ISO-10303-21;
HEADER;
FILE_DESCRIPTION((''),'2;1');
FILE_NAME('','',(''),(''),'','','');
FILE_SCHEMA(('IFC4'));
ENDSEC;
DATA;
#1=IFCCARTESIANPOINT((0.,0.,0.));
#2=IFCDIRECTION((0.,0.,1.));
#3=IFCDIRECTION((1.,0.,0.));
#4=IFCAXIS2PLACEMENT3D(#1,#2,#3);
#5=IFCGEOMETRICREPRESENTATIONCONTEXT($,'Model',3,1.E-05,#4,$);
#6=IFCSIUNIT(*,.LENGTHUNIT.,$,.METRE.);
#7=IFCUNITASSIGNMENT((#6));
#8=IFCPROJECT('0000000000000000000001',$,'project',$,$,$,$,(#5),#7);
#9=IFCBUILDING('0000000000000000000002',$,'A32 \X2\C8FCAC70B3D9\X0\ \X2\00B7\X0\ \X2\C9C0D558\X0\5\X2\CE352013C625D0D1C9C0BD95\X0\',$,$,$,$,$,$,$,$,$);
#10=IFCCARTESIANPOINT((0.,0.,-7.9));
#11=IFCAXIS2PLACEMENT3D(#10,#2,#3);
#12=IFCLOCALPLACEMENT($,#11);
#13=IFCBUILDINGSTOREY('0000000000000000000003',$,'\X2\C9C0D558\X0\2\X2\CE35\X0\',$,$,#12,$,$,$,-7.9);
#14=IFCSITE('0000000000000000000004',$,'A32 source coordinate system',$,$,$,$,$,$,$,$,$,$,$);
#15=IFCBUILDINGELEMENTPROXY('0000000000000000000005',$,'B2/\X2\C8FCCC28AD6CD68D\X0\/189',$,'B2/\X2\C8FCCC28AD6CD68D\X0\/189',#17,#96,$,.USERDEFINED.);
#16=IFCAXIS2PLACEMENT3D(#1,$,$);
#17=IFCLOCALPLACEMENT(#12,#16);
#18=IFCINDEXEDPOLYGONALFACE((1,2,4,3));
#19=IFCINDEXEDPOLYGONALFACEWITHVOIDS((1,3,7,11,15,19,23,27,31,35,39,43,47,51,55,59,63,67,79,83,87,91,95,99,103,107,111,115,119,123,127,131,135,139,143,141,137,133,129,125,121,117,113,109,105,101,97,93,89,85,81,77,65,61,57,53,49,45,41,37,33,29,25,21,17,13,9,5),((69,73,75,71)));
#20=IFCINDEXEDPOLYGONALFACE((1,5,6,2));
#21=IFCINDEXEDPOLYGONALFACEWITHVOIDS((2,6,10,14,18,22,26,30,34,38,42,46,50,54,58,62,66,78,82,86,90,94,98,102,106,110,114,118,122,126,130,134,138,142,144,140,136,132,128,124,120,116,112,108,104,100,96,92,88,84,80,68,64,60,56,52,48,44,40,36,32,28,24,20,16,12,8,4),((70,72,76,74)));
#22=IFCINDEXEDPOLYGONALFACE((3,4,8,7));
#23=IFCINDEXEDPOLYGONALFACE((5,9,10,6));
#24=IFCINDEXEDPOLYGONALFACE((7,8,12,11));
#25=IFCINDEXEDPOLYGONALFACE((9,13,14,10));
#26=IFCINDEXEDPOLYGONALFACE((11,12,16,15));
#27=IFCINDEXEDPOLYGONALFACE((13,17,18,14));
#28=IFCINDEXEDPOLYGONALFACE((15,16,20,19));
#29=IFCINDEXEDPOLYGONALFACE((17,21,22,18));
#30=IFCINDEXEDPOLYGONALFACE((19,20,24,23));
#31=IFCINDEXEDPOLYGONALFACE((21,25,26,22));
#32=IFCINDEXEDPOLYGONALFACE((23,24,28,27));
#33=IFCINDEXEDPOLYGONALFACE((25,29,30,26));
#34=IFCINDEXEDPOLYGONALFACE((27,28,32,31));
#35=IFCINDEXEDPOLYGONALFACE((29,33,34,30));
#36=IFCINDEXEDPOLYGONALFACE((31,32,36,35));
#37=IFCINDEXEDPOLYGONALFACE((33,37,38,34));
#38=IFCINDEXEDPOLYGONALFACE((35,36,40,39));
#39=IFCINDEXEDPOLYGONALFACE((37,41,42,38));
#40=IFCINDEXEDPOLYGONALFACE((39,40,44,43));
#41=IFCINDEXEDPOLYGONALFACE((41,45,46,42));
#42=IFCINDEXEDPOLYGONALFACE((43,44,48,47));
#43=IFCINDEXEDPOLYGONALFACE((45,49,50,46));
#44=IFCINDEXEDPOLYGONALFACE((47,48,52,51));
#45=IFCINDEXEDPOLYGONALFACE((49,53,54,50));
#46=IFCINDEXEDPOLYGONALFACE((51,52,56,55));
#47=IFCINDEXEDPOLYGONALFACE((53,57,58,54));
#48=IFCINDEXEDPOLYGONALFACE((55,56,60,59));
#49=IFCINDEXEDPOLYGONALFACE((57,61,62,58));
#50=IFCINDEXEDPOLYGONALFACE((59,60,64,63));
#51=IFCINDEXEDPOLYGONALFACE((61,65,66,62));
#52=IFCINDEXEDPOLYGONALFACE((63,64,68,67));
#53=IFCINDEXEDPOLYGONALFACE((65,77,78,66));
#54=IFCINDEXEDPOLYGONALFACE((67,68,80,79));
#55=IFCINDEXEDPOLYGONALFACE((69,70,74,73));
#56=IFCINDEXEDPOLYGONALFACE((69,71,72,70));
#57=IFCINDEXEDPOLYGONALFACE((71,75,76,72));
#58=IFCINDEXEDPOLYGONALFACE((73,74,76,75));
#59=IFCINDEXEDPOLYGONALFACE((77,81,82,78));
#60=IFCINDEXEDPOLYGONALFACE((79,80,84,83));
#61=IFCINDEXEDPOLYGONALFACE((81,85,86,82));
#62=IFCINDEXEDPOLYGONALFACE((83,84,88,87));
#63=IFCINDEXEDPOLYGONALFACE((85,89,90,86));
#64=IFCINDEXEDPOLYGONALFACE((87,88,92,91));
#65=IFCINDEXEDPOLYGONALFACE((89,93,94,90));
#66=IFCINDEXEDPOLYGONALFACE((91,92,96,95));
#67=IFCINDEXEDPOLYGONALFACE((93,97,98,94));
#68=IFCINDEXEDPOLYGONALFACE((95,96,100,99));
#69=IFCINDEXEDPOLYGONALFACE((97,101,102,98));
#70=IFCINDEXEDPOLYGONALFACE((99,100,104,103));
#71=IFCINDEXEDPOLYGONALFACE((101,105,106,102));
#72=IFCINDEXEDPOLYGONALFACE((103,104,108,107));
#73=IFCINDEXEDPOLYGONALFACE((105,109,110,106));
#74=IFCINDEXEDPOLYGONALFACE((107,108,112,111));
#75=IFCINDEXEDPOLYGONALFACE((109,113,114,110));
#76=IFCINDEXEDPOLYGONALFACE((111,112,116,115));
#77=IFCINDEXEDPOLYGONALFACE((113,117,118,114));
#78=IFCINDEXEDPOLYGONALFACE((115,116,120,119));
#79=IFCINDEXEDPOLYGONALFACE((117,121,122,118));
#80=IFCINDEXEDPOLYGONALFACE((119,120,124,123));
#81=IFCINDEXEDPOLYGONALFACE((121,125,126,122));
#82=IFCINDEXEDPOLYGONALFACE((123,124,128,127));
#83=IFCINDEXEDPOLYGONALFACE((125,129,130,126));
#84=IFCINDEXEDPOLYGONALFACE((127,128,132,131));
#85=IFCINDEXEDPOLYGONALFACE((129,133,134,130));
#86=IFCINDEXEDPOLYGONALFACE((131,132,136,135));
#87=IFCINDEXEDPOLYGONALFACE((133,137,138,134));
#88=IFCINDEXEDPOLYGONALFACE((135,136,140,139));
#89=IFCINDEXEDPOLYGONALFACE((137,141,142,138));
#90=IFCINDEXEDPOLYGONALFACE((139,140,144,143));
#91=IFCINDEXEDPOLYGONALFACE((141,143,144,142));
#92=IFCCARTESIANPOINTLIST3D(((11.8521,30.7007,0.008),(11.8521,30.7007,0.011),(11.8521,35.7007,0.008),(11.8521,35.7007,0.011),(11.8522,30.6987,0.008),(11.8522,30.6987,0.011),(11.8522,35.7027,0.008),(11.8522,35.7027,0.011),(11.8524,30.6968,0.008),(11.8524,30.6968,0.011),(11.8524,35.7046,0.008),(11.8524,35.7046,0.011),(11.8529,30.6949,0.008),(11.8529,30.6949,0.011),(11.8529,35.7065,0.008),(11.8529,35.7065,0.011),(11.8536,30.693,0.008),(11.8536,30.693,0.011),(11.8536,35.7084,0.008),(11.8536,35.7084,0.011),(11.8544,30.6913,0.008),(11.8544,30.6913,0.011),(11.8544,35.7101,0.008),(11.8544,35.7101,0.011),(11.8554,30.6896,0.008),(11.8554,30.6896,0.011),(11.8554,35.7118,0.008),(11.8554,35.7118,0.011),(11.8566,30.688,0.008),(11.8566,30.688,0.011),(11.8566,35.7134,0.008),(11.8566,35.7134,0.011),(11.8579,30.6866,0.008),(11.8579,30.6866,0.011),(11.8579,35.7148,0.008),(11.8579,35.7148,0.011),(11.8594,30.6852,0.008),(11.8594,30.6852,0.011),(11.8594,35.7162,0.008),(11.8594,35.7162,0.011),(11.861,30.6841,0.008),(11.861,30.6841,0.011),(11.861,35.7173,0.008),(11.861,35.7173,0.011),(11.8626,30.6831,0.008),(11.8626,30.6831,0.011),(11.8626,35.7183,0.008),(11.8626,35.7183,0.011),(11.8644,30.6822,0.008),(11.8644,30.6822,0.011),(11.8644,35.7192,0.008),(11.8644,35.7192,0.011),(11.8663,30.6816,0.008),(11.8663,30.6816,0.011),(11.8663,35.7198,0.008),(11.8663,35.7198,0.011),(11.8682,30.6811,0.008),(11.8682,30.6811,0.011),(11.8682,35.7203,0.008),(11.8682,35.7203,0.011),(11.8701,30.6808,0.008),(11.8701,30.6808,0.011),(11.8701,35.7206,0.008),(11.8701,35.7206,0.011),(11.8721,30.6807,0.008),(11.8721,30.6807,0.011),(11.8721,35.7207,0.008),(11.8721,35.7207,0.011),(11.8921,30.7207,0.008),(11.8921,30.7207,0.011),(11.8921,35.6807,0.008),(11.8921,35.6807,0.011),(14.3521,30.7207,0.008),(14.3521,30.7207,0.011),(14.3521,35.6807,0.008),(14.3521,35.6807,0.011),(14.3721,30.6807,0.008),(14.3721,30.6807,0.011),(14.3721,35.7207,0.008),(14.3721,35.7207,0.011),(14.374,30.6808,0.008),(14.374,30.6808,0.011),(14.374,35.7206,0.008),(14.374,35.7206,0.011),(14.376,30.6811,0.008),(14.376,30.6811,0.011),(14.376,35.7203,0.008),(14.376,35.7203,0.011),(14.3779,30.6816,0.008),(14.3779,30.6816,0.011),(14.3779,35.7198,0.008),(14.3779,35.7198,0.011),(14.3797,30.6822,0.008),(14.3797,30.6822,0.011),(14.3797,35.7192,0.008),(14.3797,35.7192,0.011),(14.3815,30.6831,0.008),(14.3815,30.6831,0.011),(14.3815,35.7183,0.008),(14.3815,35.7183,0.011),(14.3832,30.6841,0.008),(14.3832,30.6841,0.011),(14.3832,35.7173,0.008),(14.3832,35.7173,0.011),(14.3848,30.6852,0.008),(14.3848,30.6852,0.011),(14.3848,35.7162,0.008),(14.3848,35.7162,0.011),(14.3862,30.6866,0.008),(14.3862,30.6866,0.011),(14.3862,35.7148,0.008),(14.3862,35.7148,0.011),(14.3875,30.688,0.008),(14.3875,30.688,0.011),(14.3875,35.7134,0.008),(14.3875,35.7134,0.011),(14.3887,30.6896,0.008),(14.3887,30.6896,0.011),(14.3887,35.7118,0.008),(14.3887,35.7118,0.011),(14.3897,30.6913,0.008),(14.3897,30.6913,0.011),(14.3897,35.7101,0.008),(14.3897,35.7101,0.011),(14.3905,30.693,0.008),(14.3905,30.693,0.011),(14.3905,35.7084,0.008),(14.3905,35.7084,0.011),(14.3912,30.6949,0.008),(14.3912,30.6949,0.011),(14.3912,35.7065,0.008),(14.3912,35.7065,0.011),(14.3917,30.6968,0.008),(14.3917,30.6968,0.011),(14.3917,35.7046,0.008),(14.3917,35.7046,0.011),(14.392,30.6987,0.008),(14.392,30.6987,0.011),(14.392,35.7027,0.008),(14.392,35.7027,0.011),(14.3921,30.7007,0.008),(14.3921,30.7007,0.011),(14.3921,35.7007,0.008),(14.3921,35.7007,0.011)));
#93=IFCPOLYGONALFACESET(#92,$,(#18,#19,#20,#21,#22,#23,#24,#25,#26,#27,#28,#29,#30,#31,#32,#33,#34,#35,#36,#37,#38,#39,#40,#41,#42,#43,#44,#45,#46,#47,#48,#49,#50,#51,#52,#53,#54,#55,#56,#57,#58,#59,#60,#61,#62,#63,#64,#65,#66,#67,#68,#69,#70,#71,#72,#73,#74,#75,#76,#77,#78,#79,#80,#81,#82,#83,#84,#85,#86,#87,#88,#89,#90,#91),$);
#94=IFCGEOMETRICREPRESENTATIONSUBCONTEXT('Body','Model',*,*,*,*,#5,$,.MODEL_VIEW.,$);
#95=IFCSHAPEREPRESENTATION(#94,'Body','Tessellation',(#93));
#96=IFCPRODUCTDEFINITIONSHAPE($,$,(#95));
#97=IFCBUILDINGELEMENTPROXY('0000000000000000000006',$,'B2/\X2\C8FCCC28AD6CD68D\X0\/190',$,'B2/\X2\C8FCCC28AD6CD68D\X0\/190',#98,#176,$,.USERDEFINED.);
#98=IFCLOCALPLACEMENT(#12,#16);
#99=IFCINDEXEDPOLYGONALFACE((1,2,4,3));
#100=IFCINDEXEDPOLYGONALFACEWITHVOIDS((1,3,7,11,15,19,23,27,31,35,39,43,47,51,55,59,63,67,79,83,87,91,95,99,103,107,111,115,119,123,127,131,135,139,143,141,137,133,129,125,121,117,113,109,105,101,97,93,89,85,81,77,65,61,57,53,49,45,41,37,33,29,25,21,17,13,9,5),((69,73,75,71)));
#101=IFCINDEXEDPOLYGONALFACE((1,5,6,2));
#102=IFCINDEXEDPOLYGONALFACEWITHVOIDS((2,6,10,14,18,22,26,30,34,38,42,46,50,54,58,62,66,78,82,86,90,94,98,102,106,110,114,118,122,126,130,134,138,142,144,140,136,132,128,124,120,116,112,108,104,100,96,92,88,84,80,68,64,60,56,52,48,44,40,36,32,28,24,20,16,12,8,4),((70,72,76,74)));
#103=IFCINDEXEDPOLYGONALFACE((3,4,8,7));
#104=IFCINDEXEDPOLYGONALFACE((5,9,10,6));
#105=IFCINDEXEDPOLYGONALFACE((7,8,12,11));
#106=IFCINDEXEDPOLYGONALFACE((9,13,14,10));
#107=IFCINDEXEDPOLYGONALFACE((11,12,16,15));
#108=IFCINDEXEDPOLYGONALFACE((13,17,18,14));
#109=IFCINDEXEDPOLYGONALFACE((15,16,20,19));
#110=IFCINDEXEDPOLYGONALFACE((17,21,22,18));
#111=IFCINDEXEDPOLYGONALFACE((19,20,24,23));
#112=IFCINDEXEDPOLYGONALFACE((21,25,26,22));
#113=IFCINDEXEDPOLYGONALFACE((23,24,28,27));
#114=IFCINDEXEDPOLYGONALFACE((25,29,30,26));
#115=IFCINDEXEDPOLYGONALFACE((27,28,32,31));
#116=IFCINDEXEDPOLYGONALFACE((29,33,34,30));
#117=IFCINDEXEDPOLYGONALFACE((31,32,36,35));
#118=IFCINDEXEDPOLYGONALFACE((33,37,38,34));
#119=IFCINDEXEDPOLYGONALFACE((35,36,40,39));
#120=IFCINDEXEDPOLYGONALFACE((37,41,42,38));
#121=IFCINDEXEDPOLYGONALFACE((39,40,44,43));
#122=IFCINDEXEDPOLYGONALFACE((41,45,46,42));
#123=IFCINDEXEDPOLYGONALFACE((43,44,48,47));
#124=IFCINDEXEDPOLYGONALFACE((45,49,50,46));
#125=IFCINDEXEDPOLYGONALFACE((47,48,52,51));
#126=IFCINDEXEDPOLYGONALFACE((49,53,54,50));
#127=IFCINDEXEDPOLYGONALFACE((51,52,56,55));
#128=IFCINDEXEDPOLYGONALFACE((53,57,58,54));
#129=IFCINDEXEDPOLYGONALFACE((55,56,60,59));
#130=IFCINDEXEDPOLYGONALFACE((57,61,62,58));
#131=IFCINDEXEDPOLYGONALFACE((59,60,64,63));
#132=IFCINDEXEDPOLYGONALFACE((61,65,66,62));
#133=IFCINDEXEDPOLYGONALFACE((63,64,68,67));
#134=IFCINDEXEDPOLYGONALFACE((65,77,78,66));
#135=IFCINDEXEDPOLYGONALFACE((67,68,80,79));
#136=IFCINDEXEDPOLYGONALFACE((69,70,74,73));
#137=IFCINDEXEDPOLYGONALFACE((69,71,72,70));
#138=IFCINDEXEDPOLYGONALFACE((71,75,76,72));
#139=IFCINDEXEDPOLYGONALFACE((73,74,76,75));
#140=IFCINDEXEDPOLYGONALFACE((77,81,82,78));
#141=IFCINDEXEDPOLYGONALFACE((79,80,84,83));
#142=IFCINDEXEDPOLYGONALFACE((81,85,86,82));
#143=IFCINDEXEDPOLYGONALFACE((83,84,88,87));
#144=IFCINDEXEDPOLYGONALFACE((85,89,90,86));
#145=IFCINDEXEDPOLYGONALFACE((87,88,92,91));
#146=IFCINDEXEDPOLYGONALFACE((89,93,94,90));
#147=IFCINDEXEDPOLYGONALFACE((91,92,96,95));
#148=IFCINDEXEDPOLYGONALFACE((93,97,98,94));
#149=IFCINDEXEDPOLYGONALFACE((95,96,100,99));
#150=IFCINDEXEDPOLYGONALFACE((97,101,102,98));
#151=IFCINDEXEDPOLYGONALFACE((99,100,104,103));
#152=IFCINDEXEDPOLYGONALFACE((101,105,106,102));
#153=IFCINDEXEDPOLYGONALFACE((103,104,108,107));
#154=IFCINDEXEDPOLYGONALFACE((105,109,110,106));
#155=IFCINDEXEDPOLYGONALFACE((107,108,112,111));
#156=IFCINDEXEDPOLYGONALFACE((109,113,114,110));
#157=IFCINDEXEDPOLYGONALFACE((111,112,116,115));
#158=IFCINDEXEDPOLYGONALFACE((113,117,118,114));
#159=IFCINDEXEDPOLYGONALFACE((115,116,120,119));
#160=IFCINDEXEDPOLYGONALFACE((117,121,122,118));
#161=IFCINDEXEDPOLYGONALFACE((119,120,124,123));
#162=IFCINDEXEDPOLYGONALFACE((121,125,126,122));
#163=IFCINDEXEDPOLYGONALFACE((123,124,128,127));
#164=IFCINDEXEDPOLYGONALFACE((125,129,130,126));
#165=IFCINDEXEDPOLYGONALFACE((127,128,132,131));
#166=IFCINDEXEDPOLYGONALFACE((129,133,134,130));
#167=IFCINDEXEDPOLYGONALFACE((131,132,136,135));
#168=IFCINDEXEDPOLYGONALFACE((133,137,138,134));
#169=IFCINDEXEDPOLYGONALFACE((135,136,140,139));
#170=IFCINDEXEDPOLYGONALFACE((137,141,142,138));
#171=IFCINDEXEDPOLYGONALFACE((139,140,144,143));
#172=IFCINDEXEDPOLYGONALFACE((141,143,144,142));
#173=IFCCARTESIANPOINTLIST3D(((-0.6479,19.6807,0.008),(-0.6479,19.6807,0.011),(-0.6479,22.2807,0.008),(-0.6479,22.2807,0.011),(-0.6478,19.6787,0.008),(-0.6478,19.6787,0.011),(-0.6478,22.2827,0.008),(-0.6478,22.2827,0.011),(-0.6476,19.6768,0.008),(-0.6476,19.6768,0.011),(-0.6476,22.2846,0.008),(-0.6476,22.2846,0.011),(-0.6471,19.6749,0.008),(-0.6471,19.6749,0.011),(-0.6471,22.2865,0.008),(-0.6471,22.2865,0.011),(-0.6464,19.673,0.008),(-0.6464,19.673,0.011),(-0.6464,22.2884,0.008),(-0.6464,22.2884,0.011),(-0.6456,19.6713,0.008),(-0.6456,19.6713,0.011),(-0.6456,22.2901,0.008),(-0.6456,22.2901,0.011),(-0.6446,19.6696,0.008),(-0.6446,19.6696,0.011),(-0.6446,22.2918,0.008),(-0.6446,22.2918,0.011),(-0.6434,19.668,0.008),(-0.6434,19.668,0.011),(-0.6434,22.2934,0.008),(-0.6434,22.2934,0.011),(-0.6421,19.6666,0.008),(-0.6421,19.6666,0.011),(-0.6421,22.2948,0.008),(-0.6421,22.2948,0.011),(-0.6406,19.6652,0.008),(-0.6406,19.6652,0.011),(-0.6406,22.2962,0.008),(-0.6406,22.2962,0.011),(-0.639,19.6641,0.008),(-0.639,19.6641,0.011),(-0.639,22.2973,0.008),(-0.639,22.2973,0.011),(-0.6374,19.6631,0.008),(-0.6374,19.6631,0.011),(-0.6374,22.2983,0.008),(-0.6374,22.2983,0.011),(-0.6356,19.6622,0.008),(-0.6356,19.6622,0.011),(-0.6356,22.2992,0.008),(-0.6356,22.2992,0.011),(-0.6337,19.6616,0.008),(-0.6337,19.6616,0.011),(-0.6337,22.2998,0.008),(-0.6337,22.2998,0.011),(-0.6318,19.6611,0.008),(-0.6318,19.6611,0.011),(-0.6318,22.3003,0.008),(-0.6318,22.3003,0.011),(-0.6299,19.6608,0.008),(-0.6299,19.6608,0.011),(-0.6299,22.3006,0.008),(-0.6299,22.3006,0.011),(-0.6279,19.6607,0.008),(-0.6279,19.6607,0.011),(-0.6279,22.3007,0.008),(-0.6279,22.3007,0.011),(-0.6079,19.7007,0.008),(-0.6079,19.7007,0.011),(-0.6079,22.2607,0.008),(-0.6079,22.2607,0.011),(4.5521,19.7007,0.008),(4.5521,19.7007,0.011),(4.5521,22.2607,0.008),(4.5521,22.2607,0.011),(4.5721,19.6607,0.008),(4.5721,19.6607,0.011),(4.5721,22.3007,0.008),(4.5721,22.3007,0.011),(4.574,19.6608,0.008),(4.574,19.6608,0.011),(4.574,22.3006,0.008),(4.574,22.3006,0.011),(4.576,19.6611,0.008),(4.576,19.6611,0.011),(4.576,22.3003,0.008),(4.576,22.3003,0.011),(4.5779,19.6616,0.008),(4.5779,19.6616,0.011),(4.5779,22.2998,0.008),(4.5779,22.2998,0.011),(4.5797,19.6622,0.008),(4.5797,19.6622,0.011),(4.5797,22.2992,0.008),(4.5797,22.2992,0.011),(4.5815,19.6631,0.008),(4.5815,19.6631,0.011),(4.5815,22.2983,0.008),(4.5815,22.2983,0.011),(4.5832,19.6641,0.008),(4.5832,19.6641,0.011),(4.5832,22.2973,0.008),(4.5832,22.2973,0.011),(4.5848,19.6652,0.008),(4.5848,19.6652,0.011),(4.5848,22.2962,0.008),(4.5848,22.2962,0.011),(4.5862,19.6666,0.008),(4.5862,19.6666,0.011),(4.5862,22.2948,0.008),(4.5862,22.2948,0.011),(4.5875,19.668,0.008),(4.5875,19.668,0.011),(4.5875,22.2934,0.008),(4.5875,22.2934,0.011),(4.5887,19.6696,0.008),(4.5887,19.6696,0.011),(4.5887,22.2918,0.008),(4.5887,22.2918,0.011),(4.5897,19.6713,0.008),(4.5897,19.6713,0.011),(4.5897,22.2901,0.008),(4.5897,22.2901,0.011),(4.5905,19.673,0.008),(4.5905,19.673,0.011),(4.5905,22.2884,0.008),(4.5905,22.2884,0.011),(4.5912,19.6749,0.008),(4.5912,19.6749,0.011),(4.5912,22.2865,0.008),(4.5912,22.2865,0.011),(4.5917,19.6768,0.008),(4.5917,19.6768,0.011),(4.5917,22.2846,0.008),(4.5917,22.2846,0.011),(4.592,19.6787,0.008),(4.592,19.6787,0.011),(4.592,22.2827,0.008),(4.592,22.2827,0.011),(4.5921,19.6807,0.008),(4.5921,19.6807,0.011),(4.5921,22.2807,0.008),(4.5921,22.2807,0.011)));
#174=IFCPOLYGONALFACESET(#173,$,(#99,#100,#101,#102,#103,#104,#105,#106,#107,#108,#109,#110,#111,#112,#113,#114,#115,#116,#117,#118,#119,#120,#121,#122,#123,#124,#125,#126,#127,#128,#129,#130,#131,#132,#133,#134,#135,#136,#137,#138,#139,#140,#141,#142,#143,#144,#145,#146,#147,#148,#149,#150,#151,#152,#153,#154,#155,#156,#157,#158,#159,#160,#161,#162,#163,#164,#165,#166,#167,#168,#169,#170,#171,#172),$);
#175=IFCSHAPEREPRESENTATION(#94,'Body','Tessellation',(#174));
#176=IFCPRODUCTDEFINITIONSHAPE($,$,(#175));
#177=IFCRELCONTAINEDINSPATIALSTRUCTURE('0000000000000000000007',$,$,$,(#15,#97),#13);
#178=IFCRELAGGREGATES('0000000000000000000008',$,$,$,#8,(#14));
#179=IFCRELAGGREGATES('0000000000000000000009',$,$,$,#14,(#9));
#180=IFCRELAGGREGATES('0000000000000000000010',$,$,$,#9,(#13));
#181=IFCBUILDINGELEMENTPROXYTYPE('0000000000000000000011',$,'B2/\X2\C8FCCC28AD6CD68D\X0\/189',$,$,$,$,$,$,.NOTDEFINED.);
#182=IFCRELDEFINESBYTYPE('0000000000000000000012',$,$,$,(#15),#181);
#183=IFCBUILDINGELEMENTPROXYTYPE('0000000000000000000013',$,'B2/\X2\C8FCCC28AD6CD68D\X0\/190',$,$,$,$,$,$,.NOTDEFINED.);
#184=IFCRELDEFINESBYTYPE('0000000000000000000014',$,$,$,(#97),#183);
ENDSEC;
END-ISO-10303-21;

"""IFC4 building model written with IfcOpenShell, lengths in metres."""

from ifc_helpers import new_model, si_unit, frame, origin, origin_with_axes, place, context, subcontext, project, spatial, polyline, outline, extrude, source, transform, mapped, type_object, type_shapes, element, save


model = new_model("IFC4")

# Units and contexts
model_context = context("Model", 3, precision=1e-05, world=origin_with_axes())
body_context = subcontext(model_context, "Body", "Model", "MODEL_VIEW")
ifc_project = project(units=[si_unit("LENGTHUNIT", "METRE")], contexts=[model_context])

# Site, building, storey
site = spatial("IfcSite", under=ifc_project, Name="A32 source coordinate system")
building = spatial("IfcBuilding", under=site, Name="A32 주거동 · 지하5층–옥탑지붕")
storey_placement = place(None, frame((0.0, 0.0, -7.9), z_axis=(0.0, 0.0, 1.0), x_axis=(1.0, 0.0, 0.0)))
storey = spatial("IfcBuildingStorey", under=building, at=storey_placement, Name="지하2층", Elevation=-7.9)

# Building element proxies
building_element_proxy_type_1 = type_object("IfcBuildingElementProxyType", Name="B2/주차구획/189", PredefinedType="NOTDEFINED")
shared_shape_1 = source(origin(), body_context, "Body", "SweptSolid", [
    extrude(outline(polyline([(11.8521, 35.7007), (11.8522, 35.7027), (11.8524, 35.7046), (11.8529, 35.7065), (11.8536, 35.7084), (11.8544, 35.7101), (11.8554, 35.7118), (11.8566, 35.7134), (11.8579, 35.7148), (11.8594, 35.7162), (11.861, 35.7173), (11.8626, 35.7183), (11.8644, 35.7192), (11.8663, 35.7198), (11.8682, 35.7203), (11.8701, 35.7206), (11.8721, 35.7207), (14.3721, 35.7207), (14.374, 35.7206), (14.376, 35.7203), (14.3779, 35.7198), (14.3797, 35.7192), (14.3815, 35.7183), (14.3832, 35.7173), (14.3848, 35.7162), (14.3862, 35.7148), (14.3875, 35.7134), (14.3887, 35.7118), (14.3897, 35.7101), (14.3905, 35.7084), (14.3912, 35.7065), (14.3917, 35.7046), (14.392, 35.7027), (14.3921, 35.7007), (14.3921, 30.7007), (14.392, 30.6987), (14.3917, 30.6968), (14.3912, 30.6949), (14.3905, 30.693), (14.3897, 30.6913), (14.3887, 30.6896), (14.3875, 30.688), (14.3862, 30.6866), (14.3848, 30.6852), (14.3832, 30.6841), (14.3815, 30.6831), (14.3797, 30.6822), (14.3779, 30.6816), (14.376, 30.6811), (14.374, 30.6808), (14.3721, 30.6807), (11.8721, 30.6807), (11.8701, 30.6808), (11.8682, 30.6811), (11.8663, 30.6816), (11.8644, 30.6822), (11.8626, 30.6831), (11.861, 30.6841), (11.8594, 30.6852), (11.8579, 30.6866), (11.8566, 30.688), (11.8554, 30.6896), (11.8544, 30.6913), (11.8536, 30.693), (11.8529, 30.6949), (11.8524, 30.6968), (11.8522, 30.6987), (11.8521, 30.7007), (11.8521, 35.7007)]), holes=[polyline([(11.8921, 35.6807), (11.8921, 30.7207), (14.3521, 30.7207), (14.3521, 35.6807), (11.8921, 35.6807)])]), frame((0.0, 0.0, 0.008)), (0.0, 0.0, 1.0), 0.003),
])
type_shapes(building_element_proxy_type_1, [shared_shape_1])
proxy_1_placement = place(storey_placement, origin_with_axes())
element("IfcBuildingElementProxy", 1, at=proxy_1_placement, inside=storey, type_object=building_element_proxy_type_1, Name="B2/주차구획/189", ObjectType="B2/주차구획/189", PredefinedType="USERDEFINED", context=body_context, shape_type="MappedRepresentation", body=[
    mapped(shared_shape_1, transform((0.0, 0.0, 0.0), scale=1.0)),
])
building_element_proxy_type_2 = type_object("IfcBuildingElementProxyType", Name="B2/주차구획/190", PredefinedType="NOTDEFINED")
shared_shape_2 = source(origin(), body_context, "Body", "SweptSolid", [
    extrude(outline(polyline([(4.5921, 19.6807), (4.592, 19.6787), (4.5917, 19.6768), (4.5912, 19.6749), (4.5905, 19.673), (4.5897, 19.6713), (4.5887, 19.6696), (4.5875, 19.668), (4.5862, 19.6666), (4.5848, 19.6652), (4.5832, 19.6641), (4.5815, 19.6631), (4.5797, 19.6622), (4.5779, 19.6616), (4.576, 19.6611), (4.574, 19.6608), (4.5721, 19.6607), (-0.6279, 19.6607), (-0.6299, 19.6608), (-0.6318, 19.6611), (-0.6337, 19.6616), (-0.6356, 19.6622), (-0.6374, 19.6631), (-0.639, 19.6641), (-0.6406, 19.6652), (-0.6421, 19.6666), (-0.6434, 19.668), (-0.6446, 19.6696), (-0.6456, 19.6713), (-0.6464, 19.673), (-0.6471, 19.6749), (-0.6476, 19.6768), (-0.6478, 19.6787), (-0.6479, 19.6807), (-0.6479, 22.2807), (-0.6478, 22.2827), (-0.6476, 22.2846), (-0.6471, 22.2865), (-0.6464, 22.2884), (-0.6456, 22.2901), (-0.6446, 22.2918), (-0.6434, 22.2934), (-0.6421, 22.2948), (-0.6406, 22.2962), (-0.639, 22.2973), (-0.6374, 22.2983), (-0.6356, 22.2992), (-0.6337, 22.2998), (-0.6318, 22.3003), (-0.6299, 22.3006), (-0.6279, 22.3007), (4.5721, 22.3007), (4.574, 22.3006), (4.576, 22.3003), (4.5779, 22.2998), (4.5797, 22.2992), (4.5815, 22.2983), (4.5832, 22.2973), (4.5848, 22.2962), (4.5862, 22.2948), (4.5875, 22.2934), (4.5887, 22.2918), (4.5897, 22.2901), (4.5905, 22.2884), (4.5912, 22.2865), (4.5917, 22.2846), (4.592, 22.2827), (4.5921, 22.2807), (4.5921, 19.6807)]), holes=[polyline([(4.5521, 19.7007), (4.5521, 22.2607), (-0.6079, 22.2607), (-0.6079, 19.7007), (4.5521, 19.7007)])]), frame((0.0, 0.0, 0.008)), (0.0, 0.0, 1.0), 0.003),
])
type_shapes(building_element_proxy_type_2, [shared_shape_2])
proxy_2_placement = place(storey_placement, origin_with_axes())
element("IfcBuildingElementProxy", 2, at=proxy_2_placement, inside=storey, type_object=building_element_proxy_type_2, Name="B2/주차구획/190", ObjectType="B2/주차구획/190", PredefinedType="USERDEFINED", context=body_context, shape_type="MappedRepresentation", body=[
    mapped(shared_shape_2, transform((0.0, 0.0, 0.0), scale=1.0)),
])

save(model, "model.ifc")
